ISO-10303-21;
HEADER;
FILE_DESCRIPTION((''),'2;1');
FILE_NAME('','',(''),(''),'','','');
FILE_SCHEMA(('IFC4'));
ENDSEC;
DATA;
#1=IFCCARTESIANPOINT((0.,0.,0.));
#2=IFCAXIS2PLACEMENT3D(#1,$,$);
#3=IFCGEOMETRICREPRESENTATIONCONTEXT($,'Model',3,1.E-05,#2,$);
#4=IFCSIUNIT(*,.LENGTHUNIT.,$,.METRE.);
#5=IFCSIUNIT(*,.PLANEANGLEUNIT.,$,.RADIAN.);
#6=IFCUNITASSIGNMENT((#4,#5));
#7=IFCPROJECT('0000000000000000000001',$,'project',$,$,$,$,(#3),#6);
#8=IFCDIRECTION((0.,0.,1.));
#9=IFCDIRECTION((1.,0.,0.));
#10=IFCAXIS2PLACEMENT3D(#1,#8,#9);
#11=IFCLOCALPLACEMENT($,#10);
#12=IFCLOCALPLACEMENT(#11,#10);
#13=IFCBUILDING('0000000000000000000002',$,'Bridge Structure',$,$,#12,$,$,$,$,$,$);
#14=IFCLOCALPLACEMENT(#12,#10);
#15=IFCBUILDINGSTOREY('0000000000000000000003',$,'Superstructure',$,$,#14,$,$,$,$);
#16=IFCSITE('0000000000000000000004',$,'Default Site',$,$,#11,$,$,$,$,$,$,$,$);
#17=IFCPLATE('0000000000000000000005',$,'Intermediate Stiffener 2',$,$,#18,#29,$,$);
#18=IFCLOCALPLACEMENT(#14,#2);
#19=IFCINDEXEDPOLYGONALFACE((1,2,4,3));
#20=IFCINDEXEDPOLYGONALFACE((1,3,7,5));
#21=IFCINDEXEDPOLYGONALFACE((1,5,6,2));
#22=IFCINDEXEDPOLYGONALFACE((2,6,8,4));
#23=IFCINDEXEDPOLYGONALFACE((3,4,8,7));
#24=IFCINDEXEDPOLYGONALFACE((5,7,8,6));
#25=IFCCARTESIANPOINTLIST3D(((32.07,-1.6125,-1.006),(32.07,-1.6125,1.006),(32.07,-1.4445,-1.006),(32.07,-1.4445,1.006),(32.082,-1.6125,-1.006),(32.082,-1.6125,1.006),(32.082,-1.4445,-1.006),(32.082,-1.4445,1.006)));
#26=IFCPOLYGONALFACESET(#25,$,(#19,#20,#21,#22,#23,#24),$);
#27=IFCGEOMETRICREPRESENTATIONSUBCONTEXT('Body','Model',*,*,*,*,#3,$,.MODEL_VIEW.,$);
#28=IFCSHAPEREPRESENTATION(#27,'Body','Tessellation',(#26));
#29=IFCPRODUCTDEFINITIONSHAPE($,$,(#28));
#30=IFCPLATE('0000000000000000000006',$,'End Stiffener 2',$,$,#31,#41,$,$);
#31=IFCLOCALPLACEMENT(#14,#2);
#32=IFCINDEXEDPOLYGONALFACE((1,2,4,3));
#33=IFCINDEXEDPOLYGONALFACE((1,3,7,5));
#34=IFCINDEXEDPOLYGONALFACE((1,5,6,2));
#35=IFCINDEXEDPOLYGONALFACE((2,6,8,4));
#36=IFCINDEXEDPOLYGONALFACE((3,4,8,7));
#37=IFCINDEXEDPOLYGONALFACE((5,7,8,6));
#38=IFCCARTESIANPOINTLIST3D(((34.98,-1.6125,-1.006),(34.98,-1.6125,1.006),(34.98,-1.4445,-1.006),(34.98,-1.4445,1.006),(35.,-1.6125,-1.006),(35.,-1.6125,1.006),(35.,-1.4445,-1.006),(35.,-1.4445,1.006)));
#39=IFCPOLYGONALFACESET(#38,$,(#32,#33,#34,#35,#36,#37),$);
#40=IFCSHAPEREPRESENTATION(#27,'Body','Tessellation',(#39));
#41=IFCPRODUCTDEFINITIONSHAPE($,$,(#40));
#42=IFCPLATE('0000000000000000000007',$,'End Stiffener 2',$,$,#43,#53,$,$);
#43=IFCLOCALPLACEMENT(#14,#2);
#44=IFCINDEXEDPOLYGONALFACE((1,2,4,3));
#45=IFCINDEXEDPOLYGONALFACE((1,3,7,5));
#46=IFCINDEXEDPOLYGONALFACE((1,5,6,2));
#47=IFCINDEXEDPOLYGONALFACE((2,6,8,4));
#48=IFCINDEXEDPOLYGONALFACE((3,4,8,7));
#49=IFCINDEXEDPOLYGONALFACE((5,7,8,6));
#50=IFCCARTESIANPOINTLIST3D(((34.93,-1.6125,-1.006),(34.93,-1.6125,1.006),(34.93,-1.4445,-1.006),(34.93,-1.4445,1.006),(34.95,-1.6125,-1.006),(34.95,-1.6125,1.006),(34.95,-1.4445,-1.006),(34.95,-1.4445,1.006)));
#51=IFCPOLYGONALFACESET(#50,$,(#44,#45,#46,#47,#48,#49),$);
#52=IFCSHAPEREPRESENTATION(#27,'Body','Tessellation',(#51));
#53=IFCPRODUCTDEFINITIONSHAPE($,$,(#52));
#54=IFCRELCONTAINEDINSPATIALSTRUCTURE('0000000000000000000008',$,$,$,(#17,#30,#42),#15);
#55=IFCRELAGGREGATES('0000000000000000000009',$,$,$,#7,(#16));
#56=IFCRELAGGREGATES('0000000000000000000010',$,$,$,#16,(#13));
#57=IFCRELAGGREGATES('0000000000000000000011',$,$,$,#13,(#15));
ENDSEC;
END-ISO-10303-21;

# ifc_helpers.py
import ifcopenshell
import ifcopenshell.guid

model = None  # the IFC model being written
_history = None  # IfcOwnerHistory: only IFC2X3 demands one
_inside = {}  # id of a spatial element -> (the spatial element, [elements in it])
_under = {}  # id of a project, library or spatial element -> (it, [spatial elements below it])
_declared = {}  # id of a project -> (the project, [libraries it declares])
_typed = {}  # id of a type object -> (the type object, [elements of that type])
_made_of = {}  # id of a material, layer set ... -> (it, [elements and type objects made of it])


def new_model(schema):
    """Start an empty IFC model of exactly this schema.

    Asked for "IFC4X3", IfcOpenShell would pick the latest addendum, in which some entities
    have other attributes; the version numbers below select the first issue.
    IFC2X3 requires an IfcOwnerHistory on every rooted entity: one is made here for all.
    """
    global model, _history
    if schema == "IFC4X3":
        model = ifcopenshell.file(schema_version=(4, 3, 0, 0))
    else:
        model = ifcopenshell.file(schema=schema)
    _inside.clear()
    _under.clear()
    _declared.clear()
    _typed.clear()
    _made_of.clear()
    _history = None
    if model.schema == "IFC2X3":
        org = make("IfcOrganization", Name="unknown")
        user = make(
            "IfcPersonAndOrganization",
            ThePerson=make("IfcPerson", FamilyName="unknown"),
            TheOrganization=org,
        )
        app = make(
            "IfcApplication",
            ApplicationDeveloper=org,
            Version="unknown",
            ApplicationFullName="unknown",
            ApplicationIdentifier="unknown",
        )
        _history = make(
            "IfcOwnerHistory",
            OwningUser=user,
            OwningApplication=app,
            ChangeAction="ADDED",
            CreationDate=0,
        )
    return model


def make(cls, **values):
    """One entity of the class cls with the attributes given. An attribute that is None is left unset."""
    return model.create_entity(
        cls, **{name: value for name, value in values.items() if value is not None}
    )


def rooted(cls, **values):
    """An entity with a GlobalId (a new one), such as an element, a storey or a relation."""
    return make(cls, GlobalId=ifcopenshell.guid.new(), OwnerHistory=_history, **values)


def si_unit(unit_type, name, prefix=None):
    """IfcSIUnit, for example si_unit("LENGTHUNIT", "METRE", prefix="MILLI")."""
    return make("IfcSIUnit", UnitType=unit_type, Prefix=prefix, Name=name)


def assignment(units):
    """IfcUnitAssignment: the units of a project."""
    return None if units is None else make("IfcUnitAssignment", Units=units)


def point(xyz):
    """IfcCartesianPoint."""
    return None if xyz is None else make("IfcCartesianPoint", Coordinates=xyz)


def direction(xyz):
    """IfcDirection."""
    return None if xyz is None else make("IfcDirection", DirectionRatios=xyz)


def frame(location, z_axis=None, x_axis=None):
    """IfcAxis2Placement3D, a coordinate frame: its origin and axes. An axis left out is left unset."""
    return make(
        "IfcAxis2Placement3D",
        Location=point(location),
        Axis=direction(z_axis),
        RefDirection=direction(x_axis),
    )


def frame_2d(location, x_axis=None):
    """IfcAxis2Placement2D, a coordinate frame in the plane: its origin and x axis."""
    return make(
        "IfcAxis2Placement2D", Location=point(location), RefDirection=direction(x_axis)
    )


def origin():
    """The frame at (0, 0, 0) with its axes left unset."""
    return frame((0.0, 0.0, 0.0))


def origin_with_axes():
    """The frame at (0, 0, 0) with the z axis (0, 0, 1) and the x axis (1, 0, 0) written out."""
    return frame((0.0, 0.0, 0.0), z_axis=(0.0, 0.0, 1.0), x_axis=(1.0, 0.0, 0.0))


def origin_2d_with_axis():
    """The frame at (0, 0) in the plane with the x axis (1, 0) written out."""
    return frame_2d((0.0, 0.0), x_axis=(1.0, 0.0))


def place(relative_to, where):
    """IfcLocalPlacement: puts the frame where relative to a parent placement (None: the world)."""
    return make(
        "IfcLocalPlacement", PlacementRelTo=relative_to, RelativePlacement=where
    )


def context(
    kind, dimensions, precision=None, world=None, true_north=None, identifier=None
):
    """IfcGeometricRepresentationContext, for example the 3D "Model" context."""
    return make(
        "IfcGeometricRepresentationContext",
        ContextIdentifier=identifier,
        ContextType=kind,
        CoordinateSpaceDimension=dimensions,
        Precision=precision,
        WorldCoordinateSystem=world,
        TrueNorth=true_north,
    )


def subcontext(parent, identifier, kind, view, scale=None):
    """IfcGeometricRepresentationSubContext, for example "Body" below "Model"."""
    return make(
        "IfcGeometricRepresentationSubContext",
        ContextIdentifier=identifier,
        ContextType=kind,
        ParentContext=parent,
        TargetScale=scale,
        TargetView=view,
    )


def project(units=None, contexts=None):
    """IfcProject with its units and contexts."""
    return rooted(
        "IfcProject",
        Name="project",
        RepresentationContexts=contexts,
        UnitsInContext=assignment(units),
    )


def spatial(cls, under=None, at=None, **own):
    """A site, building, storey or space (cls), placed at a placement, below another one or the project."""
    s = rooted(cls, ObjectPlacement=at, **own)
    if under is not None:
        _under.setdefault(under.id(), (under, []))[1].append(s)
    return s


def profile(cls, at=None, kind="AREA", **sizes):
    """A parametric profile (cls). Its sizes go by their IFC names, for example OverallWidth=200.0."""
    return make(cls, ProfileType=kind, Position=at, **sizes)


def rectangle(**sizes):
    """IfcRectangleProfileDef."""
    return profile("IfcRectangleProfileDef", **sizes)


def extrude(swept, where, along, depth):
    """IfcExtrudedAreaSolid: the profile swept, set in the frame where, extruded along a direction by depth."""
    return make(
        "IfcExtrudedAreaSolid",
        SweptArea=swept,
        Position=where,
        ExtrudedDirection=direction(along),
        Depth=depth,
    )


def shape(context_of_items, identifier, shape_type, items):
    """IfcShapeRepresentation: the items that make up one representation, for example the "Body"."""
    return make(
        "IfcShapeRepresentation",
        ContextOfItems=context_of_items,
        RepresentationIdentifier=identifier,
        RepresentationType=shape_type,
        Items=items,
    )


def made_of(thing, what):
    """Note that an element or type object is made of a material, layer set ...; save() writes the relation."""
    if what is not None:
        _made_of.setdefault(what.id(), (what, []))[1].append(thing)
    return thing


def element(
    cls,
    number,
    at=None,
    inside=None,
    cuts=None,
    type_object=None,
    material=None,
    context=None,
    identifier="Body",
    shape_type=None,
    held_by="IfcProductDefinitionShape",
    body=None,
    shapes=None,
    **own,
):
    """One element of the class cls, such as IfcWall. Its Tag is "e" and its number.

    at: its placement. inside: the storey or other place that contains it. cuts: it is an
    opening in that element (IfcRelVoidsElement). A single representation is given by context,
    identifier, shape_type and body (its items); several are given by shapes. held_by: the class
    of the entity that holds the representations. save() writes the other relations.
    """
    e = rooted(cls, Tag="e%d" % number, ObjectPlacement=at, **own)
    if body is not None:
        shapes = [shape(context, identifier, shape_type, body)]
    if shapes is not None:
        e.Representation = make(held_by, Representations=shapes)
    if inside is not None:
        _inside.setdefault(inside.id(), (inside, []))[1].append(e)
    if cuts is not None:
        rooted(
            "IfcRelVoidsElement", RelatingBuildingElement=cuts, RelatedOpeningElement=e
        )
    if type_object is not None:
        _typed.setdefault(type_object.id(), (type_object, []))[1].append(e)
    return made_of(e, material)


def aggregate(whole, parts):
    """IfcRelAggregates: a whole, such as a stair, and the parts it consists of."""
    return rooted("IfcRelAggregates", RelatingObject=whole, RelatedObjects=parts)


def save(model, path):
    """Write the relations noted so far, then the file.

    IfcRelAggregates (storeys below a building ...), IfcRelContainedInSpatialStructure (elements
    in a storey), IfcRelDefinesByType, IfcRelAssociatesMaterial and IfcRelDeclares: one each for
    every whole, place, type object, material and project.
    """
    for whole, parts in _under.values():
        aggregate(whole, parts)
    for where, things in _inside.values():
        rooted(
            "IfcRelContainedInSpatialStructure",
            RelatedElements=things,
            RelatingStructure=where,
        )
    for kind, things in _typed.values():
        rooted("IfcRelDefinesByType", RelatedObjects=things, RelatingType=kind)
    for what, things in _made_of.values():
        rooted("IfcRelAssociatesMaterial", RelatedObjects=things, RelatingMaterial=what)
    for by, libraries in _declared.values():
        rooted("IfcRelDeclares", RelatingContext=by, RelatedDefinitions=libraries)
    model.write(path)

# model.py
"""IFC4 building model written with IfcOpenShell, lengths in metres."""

from ifc_helpers import new_model, si_unit, frame, origin, origin_with_axes, origin_2d_with_axis, place, context, subcontext, project, spatial, rectangle, extrude, element, save


model = new_model("IFC4")

# Units and contexts
model_context = context("Model", 3, precision=1e-05, world=origin())
body_context = subcontext(model_context, "Body", "Model", "MODEL_VIEW")
ifc_project = project(units=[si_unit("LENGTHUNIT", "METRE"), si_unit("PLANEANGLEUNIT", "RADIAN")], contexts=[model_context])

# Site, building, storey
site_placement = place(None, origin_with_axes())
site = spatial("IfcSite", under=ifc_project, at=site_placement, Name="Default Site")
building_placement = place(site_placement, origin_with_axes())
building = spatial("IfcBuilding", under=site, at=building_placement, Name="Bridge Structure")
storey_placement = place(building_placement, origin_with_axes())
storey = spatial("IfcBuildingStorey", under=building, at=storey_placement, Name="Superstructure")

# Plates
for number, where, z_axis, x_axis, name in (
    (1, (32.076, -1.5285, -1.006), (0.0, 0.0, 1.0), (1.0, 0.0, 0.0), "Intermediate Stiffener 2"),
):
    element("IfcPlate", number, at=place(storey_placement, frame(where, z_axis=z_axis, x_axis=x_axis)), inside=storey, Name=name, context=body_context, shape_type="SweptSolid", body=[
        extrude(rectangle(XDim=0.012, YDim=0.168, at=origin_2d_with_axis()), origin_with_axes(), (0.0, 0.0, 1.0), 2.012),
    ])
for number, where, z_axis, x_axis, name in (
    (2, (34.99, -1.5285, -1.006), (0.0, 0.0, 1.0), (1.0, 0.0, 0.0), "End Stiffener 2"),
    (3, (34.94, -1.5285, -1.006), (0.0, 0.0, 1.0), (1.0, 0.0, 0.0), "End Stiffener 2"),
):
    element("IfcPlate", number, at=place(storey_placement, frame(where, z_axis=z_axis, x_axis=x_axis)), inside=storey, Name=name, context=body_context, shape_type="SweptSolid", body=[
        extrude(rectangle(XDim=0.02, YDim=0.168, at=origin_2d_with_axis()), origin_with_axes(), (0.0, 0.0, 1.0), 2.012),
    ])

save(model, "model.ifc")
